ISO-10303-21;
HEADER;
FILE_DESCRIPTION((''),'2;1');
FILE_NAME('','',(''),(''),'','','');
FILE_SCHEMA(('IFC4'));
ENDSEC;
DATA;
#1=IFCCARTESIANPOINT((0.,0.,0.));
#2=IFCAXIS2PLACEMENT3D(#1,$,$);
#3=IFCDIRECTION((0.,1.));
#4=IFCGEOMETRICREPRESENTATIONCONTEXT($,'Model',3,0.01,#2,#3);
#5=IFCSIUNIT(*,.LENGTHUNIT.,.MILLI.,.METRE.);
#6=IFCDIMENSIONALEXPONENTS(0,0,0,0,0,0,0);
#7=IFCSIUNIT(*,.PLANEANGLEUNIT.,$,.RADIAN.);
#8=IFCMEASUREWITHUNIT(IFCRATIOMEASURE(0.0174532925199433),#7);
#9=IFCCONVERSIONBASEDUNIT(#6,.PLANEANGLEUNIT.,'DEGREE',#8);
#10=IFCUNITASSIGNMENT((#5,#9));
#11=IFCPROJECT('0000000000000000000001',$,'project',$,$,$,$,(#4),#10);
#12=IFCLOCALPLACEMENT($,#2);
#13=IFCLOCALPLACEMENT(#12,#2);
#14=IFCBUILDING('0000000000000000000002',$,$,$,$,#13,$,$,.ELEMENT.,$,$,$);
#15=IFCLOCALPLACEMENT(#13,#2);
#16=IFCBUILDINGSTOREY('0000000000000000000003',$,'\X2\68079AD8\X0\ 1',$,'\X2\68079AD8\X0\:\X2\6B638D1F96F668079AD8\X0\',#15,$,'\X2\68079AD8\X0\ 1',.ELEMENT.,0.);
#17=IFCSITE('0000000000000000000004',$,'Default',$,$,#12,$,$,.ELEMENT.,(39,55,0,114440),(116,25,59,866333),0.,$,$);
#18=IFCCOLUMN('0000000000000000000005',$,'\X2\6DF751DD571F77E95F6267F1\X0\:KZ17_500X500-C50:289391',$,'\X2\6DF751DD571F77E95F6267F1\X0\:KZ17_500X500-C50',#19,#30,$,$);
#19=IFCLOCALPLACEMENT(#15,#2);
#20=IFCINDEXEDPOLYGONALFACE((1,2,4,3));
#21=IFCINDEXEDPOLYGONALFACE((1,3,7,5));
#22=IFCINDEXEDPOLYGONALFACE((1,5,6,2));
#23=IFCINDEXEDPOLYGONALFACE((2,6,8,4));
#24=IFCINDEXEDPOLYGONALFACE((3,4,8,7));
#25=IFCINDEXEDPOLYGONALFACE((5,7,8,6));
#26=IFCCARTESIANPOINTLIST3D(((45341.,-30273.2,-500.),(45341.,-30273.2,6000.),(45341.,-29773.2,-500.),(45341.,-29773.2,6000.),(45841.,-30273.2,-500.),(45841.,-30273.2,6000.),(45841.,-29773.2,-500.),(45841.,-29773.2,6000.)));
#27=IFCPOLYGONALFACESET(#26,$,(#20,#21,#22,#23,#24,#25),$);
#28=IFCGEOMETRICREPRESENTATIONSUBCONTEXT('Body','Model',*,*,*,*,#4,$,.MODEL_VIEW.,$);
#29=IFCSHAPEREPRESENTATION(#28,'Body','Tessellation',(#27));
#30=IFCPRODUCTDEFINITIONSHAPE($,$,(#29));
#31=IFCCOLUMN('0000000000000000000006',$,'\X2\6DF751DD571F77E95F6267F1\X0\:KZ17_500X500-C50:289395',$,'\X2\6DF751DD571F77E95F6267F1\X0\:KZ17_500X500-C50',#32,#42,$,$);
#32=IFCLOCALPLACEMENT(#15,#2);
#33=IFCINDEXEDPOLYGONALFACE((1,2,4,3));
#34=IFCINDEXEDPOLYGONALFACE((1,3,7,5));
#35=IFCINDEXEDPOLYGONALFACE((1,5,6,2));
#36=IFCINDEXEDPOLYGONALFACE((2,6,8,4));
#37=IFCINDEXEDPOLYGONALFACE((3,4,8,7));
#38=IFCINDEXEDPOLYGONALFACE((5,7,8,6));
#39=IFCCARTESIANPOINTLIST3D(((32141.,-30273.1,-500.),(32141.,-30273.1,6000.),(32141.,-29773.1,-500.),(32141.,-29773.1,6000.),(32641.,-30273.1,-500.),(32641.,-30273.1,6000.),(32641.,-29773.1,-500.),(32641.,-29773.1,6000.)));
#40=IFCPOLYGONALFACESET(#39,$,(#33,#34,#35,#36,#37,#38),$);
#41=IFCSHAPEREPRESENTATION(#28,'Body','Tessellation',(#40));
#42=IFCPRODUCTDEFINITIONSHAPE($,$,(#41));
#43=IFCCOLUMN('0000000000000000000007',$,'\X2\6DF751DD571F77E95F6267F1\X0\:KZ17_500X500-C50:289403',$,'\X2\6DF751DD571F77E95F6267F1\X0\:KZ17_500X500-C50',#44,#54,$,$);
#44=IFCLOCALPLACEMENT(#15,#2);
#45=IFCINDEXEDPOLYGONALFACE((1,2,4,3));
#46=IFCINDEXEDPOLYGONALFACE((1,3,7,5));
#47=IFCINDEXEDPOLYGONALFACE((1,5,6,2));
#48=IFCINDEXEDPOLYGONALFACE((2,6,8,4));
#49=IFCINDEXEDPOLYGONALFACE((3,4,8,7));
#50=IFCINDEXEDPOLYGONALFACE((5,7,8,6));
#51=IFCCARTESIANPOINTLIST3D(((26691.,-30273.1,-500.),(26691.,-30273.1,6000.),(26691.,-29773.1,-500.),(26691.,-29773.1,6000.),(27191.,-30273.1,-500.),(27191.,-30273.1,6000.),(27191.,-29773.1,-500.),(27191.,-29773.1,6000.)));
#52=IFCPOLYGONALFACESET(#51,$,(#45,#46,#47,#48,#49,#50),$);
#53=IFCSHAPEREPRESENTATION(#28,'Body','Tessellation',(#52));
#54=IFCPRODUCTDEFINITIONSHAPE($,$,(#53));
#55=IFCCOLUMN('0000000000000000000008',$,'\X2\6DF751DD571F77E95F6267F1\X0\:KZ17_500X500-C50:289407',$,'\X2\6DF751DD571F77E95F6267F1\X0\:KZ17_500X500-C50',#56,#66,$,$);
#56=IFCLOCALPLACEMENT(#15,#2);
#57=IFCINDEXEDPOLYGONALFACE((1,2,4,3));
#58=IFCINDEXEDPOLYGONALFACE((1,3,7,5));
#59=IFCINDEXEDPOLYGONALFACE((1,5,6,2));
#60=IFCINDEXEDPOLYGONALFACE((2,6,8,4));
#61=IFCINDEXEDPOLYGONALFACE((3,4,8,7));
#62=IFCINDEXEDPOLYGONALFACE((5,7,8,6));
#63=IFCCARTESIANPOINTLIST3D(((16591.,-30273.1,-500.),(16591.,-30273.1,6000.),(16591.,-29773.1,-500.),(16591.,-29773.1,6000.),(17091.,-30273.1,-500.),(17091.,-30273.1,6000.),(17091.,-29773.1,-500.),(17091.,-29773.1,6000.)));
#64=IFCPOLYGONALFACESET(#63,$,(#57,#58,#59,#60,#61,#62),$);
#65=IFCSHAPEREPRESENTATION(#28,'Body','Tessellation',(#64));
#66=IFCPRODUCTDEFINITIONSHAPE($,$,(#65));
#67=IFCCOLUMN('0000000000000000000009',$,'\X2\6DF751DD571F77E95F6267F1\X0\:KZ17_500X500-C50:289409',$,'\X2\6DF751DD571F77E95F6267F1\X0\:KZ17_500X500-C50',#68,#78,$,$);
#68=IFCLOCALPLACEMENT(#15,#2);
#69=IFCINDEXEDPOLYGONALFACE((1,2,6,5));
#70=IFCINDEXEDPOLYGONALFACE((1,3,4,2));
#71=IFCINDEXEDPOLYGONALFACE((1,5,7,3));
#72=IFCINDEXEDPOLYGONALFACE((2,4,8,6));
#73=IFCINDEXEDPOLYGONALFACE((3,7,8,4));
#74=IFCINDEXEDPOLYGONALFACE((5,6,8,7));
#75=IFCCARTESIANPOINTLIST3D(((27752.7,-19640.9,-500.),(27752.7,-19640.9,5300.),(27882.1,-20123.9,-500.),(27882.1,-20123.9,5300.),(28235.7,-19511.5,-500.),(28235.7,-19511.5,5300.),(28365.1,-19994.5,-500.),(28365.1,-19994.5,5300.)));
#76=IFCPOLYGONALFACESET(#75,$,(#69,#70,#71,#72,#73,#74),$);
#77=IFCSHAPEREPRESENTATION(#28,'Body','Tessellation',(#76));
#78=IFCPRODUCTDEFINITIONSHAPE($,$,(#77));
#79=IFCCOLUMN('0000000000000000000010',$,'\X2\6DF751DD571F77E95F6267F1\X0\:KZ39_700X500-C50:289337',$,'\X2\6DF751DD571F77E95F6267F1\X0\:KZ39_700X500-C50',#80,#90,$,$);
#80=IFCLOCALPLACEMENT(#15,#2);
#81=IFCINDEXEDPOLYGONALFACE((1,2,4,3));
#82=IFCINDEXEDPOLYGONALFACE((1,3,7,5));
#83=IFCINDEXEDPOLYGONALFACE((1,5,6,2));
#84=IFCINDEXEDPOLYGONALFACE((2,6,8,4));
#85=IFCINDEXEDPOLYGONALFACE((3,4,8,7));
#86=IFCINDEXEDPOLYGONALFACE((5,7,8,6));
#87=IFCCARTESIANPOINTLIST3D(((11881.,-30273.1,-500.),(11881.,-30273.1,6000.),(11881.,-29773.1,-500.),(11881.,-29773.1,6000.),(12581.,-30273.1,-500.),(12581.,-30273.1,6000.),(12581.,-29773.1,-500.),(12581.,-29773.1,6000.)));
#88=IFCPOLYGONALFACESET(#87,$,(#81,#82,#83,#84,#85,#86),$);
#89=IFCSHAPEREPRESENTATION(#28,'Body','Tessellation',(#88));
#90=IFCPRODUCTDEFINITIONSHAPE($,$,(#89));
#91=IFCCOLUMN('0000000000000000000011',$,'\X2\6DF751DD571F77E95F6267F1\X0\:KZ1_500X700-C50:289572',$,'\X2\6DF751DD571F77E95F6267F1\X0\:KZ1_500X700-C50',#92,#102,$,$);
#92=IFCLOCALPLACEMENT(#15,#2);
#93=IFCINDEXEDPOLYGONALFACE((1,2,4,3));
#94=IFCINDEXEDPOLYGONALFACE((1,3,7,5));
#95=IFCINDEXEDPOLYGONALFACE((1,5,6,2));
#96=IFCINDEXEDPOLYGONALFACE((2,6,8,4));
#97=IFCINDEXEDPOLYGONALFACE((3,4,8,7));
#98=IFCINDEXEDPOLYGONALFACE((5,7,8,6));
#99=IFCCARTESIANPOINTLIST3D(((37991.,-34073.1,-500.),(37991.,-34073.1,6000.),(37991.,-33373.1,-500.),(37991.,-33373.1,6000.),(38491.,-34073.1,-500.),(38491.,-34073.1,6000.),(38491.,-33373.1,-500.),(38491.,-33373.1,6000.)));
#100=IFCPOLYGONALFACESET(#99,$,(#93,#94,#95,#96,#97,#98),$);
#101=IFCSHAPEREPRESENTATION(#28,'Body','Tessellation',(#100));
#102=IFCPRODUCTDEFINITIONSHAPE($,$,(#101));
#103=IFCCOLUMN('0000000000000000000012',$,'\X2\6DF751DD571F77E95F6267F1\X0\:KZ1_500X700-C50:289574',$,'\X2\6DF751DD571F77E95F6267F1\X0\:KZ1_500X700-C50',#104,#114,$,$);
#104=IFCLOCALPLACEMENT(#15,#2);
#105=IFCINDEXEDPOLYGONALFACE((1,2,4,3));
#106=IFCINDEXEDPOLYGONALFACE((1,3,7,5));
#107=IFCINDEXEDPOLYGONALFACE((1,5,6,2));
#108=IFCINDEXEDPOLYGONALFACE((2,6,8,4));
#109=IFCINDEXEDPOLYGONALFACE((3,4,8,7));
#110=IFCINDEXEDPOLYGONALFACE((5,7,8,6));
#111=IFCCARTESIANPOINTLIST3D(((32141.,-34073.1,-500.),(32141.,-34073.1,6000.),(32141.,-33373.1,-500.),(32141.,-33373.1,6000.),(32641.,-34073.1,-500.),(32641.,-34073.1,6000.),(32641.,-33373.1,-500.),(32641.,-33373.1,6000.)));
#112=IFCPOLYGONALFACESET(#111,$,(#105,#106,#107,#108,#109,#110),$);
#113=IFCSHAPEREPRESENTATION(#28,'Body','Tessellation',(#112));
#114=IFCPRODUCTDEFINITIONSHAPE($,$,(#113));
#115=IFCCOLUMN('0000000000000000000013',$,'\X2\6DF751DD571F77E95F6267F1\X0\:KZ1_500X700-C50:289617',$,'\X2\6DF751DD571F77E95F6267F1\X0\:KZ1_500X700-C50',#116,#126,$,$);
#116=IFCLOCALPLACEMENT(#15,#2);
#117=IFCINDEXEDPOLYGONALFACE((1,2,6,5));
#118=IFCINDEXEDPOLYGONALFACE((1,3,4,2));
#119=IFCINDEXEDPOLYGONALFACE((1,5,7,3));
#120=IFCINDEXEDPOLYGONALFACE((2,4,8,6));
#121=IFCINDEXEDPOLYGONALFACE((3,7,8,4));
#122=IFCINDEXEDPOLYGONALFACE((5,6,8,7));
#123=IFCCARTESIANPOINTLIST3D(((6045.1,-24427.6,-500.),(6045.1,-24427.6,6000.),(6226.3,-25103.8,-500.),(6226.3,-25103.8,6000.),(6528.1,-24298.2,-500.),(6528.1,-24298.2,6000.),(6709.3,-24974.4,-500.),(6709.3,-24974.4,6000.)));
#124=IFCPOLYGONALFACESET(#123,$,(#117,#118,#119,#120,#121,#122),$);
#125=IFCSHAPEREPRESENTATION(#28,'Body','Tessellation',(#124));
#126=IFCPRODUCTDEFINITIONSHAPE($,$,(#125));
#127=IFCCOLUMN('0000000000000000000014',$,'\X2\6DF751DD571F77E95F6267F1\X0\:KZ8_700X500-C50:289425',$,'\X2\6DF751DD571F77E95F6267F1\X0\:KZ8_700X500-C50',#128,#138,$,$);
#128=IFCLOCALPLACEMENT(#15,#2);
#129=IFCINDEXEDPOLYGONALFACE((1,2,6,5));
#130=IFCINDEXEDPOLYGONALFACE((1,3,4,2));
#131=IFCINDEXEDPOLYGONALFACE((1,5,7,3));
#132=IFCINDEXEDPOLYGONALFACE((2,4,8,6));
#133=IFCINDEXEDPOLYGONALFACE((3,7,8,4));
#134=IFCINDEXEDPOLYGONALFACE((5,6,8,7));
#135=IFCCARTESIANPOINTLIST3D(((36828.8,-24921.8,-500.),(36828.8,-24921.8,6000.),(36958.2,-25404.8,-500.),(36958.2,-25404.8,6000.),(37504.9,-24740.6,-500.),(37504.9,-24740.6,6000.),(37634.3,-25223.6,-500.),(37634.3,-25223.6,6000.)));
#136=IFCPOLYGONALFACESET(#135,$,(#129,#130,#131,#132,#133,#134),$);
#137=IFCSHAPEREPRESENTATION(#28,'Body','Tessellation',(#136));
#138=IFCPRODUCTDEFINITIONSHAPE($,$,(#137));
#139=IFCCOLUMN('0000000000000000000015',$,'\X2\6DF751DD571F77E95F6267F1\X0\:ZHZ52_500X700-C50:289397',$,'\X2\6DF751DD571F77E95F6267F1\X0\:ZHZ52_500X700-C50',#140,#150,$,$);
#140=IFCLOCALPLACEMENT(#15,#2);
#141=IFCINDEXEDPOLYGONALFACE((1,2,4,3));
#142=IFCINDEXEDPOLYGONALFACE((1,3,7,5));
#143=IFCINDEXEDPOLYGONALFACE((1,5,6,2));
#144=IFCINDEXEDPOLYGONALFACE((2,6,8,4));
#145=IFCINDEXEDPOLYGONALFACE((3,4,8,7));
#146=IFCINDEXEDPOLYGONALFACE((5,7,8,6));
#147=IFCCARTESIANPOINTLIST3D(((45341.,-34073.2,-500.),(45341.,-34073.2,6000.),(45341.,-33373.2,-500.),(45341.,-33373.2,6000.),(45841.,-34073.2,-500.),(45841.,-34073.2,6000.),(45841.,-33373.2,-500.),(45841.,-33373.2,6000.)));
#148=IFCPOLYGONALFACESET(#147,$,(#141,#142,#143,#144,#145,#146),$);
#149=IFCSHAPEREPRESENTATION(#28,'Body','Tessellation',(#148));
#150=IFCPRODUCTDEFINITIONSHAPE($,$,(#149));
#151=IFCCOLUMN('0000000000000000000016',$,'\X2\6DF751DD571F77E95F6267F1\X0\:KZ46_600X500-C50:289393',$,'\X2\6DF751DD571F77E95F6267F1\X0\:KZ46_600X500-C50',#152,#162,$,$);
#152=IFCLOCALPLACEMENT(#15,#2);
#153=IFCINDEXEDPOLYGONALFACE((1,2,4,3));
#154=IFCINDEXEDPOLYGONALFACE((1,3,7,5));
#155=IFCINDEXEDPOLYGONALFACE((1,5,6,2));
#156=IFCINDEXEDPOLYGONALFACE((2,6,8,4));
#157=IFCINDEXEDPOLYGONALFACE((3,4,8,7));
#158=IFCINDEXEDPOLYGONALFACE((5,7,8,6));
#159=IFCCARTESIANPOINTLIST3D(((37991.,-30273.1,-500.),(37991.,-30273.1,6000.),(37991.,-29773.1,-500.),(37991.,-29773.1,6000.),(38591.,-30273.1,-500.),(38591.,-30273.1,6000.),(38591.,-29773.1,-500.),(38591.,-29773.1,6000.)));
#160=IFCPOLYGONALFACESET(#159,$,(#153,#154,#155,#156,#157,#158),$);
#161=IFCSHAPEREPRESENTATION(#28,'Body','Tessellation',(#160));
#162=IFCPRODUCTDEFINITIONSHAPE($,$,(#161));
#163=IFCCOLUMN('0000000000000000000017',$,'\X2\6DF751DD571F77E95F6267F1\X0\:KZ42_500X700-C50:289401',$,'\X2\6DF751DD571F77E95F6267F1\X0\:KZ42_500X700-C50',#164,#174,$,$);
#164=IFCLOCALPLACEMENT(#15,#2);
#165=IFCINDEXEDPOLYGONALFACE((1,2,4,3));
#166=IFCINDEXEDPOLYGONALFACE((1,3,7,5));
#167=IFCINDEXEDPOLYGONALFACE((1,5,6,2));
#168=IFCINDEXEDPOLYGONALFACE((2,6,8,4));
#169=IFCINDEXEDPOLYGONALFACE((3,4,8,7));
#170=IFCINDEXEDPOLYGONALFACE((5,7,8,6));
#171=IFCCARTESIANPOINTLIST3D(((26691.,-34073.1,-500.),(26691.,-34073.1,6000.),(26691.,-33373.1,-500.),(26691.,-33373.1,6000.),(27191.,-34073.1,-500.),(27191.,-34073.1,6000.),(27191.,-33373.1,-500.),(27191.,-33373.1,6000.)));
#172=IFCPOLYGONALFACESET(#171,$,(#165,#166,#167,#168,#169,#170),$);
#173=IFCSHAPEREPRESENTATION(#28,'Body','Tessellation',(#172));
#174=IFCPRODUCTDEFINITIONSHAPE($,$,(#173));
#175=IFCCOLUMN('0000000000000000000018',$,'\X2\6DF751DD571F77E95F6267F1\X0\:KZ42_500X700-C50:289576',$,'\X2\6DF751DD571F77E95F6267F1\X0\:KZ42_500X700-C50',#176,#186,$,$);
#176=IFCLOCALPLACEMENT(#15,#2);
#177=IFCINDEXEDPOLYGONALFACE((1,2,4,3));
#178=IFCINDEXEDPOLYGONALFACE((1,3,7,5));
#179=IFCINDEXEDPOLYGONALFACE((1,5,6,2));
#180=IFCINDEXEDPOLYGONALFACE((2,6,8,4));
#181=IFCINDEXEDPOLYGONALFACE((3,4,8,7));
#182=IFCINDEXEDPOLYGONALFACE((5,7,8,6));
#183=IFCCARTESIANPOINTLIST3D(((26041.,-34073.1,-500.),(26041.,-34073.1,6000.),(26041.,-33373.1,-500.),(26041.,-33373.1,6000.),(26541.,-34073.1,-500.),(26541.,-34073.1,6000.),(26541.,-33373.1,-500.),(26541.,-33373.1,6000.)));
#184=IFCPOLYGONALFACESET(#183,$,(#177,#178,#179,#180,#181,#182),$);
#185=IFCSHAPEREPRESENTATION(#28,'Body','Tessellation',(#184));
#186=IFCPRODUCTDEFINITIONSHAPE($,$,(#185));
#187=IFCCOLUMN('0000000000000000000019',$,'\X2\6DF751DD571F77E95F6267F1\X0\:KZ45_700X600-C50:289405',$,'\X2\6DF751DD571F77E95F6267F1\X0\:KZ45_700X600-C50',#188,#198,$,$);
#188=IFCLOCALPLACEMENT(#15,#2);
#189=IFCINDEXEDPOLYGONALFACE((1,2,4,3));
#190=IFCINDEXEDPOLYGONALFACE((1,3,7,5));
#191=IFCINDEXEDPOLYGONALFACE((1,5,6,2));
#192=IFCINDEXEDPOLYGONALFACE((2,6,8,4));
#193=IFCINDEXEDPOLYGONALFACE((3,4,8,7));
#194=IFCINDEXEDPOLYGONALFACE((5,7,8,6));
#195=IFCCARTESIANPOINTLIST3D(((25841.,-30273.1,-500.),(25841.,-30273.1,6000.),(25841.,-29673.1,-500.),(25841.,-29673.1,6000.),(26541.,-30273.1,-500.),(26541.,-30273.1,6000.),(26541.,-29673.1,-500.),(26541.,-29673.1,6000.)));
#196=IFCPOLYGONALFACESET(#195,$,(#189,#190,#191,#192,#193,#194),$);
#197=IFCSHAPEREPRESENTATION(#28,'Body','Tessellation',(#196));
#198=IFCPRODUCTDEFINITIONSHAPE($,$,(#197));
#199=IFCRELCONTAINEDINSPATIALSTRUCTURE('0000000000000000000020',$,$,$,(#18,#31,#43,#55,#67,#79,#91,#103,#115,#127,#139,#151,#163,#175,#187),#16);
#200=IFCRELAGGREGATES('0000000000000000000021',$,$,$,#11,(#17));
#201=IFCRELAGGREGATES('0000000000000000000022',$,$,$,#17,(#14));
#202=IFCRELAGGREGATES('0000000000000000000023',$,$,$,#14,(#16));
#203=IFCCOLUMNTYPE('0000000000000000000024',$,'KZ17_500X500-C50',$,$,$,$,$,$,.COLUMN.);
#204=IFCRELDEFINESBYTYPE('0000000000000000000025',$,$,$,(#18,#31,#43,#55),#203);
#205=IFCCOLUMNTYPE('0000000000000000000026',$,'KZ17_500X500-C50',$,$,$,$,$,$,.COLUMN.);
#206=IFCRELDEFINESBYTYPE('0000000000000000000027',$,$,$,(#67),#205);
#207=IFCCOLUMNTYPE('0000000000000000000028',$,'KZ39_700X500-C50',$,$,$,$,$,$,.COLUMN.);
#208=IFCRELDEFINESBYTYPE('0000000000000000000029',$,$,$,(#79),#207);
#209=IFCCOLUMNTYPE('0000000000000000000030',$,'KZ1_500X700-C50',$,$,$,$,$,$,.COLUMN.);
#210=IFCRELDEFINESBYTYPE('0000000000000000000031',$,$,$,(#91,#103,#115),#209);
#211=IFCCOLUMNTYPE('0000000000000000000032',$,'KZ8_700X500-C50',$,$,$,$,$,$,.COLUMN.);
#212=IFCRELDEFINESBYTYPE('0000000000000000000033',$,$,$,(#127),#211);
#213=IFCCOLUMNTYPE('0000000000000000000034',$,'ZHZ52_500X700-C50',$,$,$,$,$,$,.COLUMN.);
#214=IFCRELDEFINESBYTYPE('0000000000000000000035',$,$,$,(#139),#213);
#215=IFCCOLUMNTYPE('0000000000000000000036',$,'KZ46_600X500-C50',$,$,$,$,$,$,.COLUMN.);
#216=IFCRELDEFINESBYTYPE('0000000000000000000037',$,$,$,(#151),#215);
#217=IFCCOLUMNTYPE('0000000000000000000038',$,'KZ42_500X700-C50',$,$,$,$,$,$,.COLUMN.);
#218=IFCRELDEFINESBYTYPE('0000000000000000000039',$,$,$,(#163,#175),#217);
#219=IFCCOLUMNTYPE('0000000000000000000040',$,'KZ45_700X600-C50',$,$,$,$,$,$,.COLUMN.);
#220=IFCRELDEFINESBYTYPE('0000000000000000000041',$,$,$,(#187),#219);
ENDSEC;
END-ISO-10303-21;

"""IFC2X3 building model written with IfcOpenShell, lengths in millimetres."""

from ifc_helpers import new_model, entity, si_unit, converted_unit, direction, frame, origin, origin_2d_with_axis, place, context, subcontext, project, spatial, rectangle, extrude, source, transform, mapped, type_object, type_shapes, element, save


model = new_model("IFC2X3")

# Units and contexts
model_context = context("Model", 3, precision=0.01, world=origin(), true_north=direction((0.0, 1.0)))
body_context = subcontext(model_context, "Body", "Model", "MODEL_VIEW")
ifc_project = project(units=[si_unit("LENGTHUNIT", "METRE", prefix="MILLI"), converted_unit("PLANEANGLEUNIT", "DEGREE", entity("IfcRatioMeasure", 0.0174532925199433), si_unit("PLANEANGLEUNIT", "RADIAN"), dimensions=[0, 0, 0, 0, 0, 0, 0])], contexts=[model_context])

# Site, building, storey
site_placement = place(None, origin())
site = spatial("IfcSite", under=ifc_project, at=site_placement, Name="Default", CompositionType="ELEMENT", RefLatitude=(39, 55, 0, 114440), RefLongitude=(116, 25, 59, 866333), RefElevation=0.0)
building_placement = place(site_placement, origin())
building = spatial("IfcBuilding", under=site, at=building_placement, CompositionType="ELEMENT")
storey_placement = place(building_placement, origin())
storey = spatial("IfcBuildingStorey", under=building, at=storey_placement, Name="标高 1", ObjectType="标高:正负零标高", LongName="标高 1", CompositionType="ELEMENT", Elevation=0.0)

# Columns
column_type_1 = type_object("IfcColumnType", Name="KZ17_500X500-C50", PredefinedType="COLUMN")
shared_shape_1 = source(origin(), body_context, "Body", "SweptSolid", [
    extrude(rectangle(XDim=500.0, YDim=500.0, at=origin_2d_with_axis()), frame((0.0, 0.0, -500.0), z_axis=(0.0, 0.0, 1.0), x_axis=(0.0, -1.0, 0.0)), (0.0, 0.0, 1.0), 6500.0),
])
type_shapes(column_type_1, [shared_shape_1])
for number, where, name in (
    (1, (45591.0, -30023.2, 0.0), "混凝土矩形柱:KZ17_500X500-C50:289391"),
    (2, (32391.0, -30023.1, 0.0), "混凝土矩形柱:KZ17_500X500-C50:289395"),
    (3, (26941.0, -30023.1, 0.0), "混凝土矩形柱:KZ17_500X500-C50:289403"),
    (4, (16841.0, -30023.1, 0.0), "混凝土矩形柱:KZ17_500X500-C50:289407"),
):
    element("IfcColumn", number, at=place(building_placement, frame(where)), inside=storey, type_object=column_type_1, Name=name, ObjectType="混凝土矩形柱:KZ17_500X500-C50", context=body_context, shape_type="MappedRepresentation", body=[
        mapped(shared_shape_1, transform((0.0, 0.0, 0.0), scale=1.0)),
    ])
column_type_2 = type_object("IfcColumnType", Name="KZ17_500X500-C50", PredefinedType="COLUMN")
shared_shape_2 = source(origin(), body_context, "Body", "SweptSolid", [
    extrude(rectangle(XDim=500.0, YDim=500.0, at=origin_2d_with_axis()), frame((0.0, 0.0, -500.0), z_axis=(0.0, 0.0, 1.0), x_axis=(0.0, -1.0, 0.0)), (0.0, 0.0, 1.0), 5800.0),
])
type_shapes(column_type_2, [shared_shape_2])
column_1_placement = place(building_placement, frame((28058.9, -19817.7, 0.0), z_axis=(0.0, 0.0, 1.0), x_axis=(0.258819, -0.965926, 0.0)))
element("IfcColumn", 5, at=column_1_placement, inside=storey, type_object=column_type_2, Name="混凝土矩形柱:KZ17_500X500-C50:289409", ObjectType="混凝土矩形柱:KZ17_500X500-C50", context=body_context, shape_type="MappedRepresentation", body=[
    mapped(shared_shape_2, transform((0.0, 0.0, 0.0), scale=1.0)),
])
column_type_3 = type_object("IfcColumnType", Name="KZ39_700X500-C50", PredefinedType="COLUMN")
shared_shape_3 = source(origin(), body_context, "Body", "SweptSolid", [
    extrude(rectangle(XDim=500.0, YDim=700.0, at=origin_2d_with_axis()), frame((0.0, 0.0, -500.0), z_axis=(0.0, 0.0, 1.0), x_axis=(0.0, -1.0, 0.0)), (0.0, 0.0, 1.0), 6500.0),
])
type_shapes(column_type_3, [shared_shape_3])
column_2_placement = place(building_placement, frame((12231.0, -30023.1, 0.0)))
element("IfcColumn", 6, at=column_2_placement, inside=storey, type_object=column_type_3, Name="混凝土矩形柱:KZ39_700X500-C50:289337", ObjectType="混凝土矩形柱:KZ39_700X500-C50", context=body_context, shape_type="MappedRepresentation", body=[
    mapped(shared_shape_3, transform((0.0, 0.0, 0.0), scale=1.0)),
])
column_type_4 = type_object("IfcColumnType", Name="KZ1_500X700-C50", PredefinedType="COLUMN")
shared_shape_4 = source(origin(), body_context, "Body", "SweptSolid", [
    extrude(rectangle(XDim=700.0, YDim=500.0, at=origin_2d_with_axis()), frame((0.0, 0.0, -500.0), z_axis=(0.0, 0.0, 1.0), x_axis=(0.0, -1.0, 0.0)), (0.0, 0.0, 1.0), 6500.0),
])
type_shapes(column_type_4, [shared_shape_4])
for number, where, name in (
    (7, (38241.0, -33723.1, 0.0), "混凝土矩形柱:KZ1_500X700-C50:289572"),
    (8, (32391.0, -33723.1, 0.0), "混凝土矩形柱:KZ1_500X700-C50:289574"),
):
    element("IfcColumn", number, at=place(building_placement, frame(where)), inside=storey, type_object=column_type_4, Name=name, ObjectType="混凝土矩形柱:KZ1_500X700-C50", context=body_context, shape_type="MappedRepresentation", body=[
        mapped(shared_shape_4, transform((0.0, 0.0, 0.0), scale=1.0)),
    ])
column_3_placement = place(building_placement, frame((6377.2, -24701.0, 0.0), z_axis=(0.0, 0.0, 1.0), x_axis=(0.965926, 0.258819, 0.0)))
element("IfcColumn", 9, at=column_3_placement, inside=storey, type_object=column_type_4, Name="混凝土矩形柱:KZ1_500X700-C50:289617", ObjectType="混凝土矩形柱:KZ1_500X700-C50", context=body_context, shape_type="MappedRepresentation", body=[
    mapped(shared_shape_4, transform((0.0, 0.0, 0.0), scale=1.0)),
])
column_type_5 = type_object("IfcColumnType", Name="KZ8_700X500-C50", PredefinedType="COLUMN")
shared_shape_5 = source(origin(), body_context, "Body", "SweptSolid", [
    extrude(rectangle(XDim=500.0, YDim=700.0, at=origin_2d_with_axis()), frame((0.0, 0.0, -500.0), z_axis=(0.0, 0.0, 1.0), x_axis=(0.0, -1.0, 0.0)), (0.0, 0.0, 1.0), 6500.0),
])
type_shapes(column_type_5, [shared_shape_5])
column_4_placement = place(building_placement, frame((37231.5, -25072.7, 0.0), z_axis=(0.0, 0.0, 1.0), x_axis=(0.965926, 0.258819, 0.0)))
element("IfcColumn", 10, at=column_4_placement, inside=storey, type_object=column_type_5, Name="混凝土矩形柱:KZ8_700X500-C50:289425", ObjectType="混凝土矩形柱:KZ8_700X500-C50", context=body_context, shape_type="MappedRepresentation", body=[
    mapped(shared_shape_5, transform((0.0, 0.0, 0.0), scale=1.0)),
])
column_type_6 = type_object("IfcColumnType", Name="ZHZ52_500X700-C50", PredefinedType="COLUMN")
shared_shape_6 = source(origin(), body_context, "Body", "SweptSolid", [
    extrude(rectangle(XDim=700.0, YDim=500.0, at=origin_2d_with_axis()), frame((0.0, 0.0, -500.0), z_axis=(0.0, 0.0, 1.0), x_axis=(0.0, -1.0, 0.0)), (0.0, 0.0, 1.0), 6500.0),
])
type_shapes(column_type_6, [shared_shape_6])
column_5_placement = place(building_placement, frame((45591.0, -33723.2, 0.0)))
element("IfcColumn", 11, at=column_5_placement, inside=storey, type_object=column_type_6, Name="混凝土矩形柱:ZHZ52_500X700-C50:289397", ObjectType="混凝土矩形柱:ZHZ52_500X700-C50", context=body_context, shape_type="MappedRepresentation", body=[
    mapped(shared_shape_6, transform((0.0, 0.0, 0.0), scale=1.0)),
])
column_type_7 = type_object("IfcColumnType", Name="KZ46_600X500-C50", PredefinedType="COLUMN")
shared_shape_7 = source(origin(), body_context, "Body", "SweptSolid", [
    extrude(rectangle(XDim=500.0, YDim=600.0, at=origin_2d_with_axis()), frame((0.0, 0.0, -500.0), z_axis=(0.0, 0.0, 1.0), x_axis=(0.0, -1.0, 0.0)), (0.0, 0.0, 1.0), 6500.0),
])
type_shapes(column_type_7, [shared_shape_7])
column_6_placement = place(building_placement, frame((38291.0, -30023.1, 0.0)))
element("IfcColumn", 12, at=column_6_placement, inside=storey, type_object=column_type_7, Name="混凝土矩形柱:KZ46_600X500-C50:289393", ObjectType="混凝土矩形柱:KZ46_600X500-C50", context=body_context, shape_type="MappedRepresentation", body=[
    mapped(shared_shape_7, transform((0.0, 0.0, 0.0), scale=1.0)),
])
column_type_8 = type_object("IfcColumnType", Name="KZ42_500X700-C50", PredefinedType="COLUMN")
shared_shape_8 = source(origin(), body_context, "Body", "SweptSolid", [
    extrude(rectangle(XDim=700.0, YDim=500.0, at=origin_2d_with_axis()), frame((0.0, 0.0, -500.0), z_axis=(0.0, 0.0, 1.0), x_axis=(0.0, -1.0, 0.0)), (0.0, 0.0, 1.0), 6500.0),
])
type_shapes(column_type_8, [shared_shape_8])
for number, where, name in (
    (13, (26941.0, -33723.1, 0.0), "混凝土矩形柱:KZ42_500X700-C50:289401"),
    (14, (26291.0, -33723.1, 0.0), "混凝土矩形柱:KZ42_500X700-C50:289576"),
):
    element("IfcColumn", number, at=place(building_placement, frame(where)), inside=storey, type_object=column_type_8, Name=name, ObjectType="混凝土矩形柱:KZ42_500X700-C50", context=body_context, shape_type="MappedRepresentation", body=[
        mapped(shared_shape_8, transform((0.0, 0.0, 0.0), scale=1.0)),
    ])
column_type_9 = type_object("IfcColumnType", Name="KZ45_700X600-C50", PredefinedType="COLUMN")
shared_shape_9 = source(origin(), body_context, "Body", "SweptSolid", [
    extrude(rectangle(XDim=600.0, YDim=700.0, at=origin_2d_with_axis()), frame((0.0, 0.0, -500.0), z_axis=(0.0, 0.0, 1.0), x_axis=(0.0, -1.0, 0.0)), (0.0, 0.0, 1.0), 6500.0),
])
type_shapes(column_type_9, [shared_shape_9])
column_7_placement = place(building_placement, frame((26191.0, -29973.1, 0.0)))
element("IfcColumn", 15, at=column_7_placement, inside=storey, type_object=column_type_9, Name="混凝土矩形柱:KZ45_700X600-C50:289405", ObjectType="混凝土矩形柱:KZ45_700X600-C50", context=body_context, shape_type="MappedRepresentation", body=[
    mapped(shared_shape_9, transform((0.0, 0.0, 0.0), scale=1.0)),
])

save(model, "model.ifc")
